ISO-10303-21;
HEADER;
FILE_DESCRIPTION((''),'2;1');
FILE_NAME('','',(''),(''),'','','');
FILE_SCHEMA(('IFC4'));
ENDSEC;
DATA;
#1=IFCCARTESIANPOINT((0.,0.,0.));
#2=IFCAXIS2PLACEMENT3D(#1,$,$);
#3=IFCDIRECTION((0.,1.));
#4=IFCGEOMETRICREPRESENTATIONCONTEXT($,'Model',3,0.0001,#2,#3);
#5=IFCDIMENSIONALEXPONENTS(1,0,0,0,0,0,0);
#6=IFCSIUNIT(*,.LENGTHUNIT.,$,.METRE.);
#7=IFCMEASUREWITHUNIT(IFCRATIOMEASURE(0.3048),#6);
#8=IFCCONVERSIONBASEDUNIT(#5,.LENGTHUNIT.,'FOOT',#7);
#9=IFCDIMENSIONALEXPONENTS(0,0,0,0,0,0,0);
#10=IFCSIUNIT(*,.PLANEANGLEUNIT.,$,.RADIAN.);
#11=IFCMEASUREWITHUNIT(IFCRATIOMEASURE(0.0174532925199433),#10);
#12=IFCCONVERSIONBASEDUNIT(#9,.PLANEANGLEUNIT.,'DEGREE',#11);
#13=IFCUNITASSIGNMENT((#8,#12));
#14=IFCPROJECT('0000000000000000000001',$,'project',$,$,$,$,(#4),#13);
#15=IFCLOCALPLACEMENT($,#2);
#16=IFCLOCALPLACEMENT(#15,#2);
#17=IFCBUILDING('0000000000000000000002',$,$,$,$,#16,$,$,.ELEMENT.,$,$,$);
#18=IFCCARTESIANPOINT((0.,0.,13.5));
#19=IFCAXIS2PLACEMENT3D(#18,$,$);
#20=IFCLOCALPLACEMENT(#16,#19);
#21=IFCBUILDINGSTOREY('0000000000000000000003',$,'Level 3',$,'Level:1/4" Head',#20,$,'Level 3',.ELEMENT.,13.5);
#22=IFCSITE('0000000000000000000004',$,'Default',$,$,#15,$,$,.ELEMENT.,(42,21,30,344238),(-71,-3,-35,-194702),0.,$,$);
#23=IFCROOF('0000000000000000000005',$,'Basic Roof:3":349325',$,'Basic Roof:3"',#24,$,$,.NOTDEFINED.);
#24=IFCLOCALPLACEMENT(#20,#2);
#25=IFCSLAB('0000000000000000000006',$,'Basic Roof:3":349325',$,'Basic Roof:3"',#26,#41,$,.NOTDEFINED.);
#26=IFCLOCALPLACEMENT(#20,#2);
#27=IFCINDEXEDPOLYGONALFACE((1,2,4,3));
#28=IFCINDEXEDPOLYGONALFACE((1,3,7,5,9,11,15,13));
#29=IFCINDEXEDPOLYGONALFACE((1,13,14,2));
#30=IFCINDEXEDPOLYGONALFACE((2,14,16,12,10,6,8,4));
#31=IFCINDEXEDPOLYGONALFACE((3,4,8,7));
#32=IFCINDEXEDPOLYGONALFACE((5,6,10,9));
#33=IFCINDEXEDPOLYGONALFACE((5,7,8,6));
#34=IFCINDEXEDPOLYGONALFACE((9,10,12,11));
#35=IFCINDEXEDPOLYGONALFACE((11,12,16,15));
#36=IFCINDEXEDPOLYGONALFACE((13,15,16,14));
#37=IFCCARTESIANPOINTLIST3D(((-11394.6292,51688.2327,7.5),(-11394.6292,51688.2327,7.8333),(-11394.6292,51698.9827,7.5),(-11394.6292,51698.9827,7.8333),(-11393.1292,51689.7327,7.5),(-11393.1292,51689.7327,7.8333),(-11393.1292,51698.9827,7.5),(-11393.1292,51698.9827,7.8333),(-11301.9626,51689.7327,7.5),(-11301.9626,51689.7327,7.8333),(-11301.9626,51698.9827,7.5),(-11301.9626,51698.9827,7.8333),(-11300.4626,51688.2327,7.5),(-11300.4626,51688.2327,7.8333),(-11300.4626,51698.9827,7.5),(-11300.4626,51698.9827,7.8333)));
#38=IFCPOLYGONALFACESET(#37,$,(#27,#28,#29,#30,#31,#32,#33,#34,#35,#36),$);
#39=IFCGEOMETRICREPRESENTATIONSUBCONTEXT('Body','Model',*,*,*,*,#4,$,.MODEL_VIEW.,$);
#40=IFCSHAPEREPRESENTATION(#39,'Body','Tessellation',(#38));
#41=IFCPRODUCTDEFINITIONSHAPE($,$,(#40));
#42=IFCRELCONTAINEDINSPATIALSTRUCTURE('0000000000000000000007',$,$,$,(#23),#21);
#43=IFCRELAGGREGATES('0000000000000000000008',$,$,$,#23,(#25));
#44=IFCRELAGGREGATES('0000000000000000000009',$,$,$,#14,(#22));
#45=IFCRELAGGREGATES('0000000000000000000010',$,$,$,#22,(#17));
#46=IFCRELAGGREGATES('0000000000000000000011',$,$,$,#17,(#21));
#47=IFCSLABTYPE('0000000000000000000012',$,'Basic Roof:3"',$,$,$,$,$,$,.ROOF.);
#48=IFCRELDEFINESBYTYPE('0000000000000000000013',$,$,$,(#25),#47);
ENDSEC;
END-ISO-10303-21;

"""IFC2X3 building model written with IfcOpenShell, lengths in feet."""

from ifc_helpers import new_model, entity, si_unit, converted_unit, direction, frame, origin, place, context, subcontext, project, spatial, polyline, outline, extrude, type_object, element, aggregate, save


model = new_model("IFC2X3")

# Units and contexts
model_context = context("Model", 3, precision=0.0001, world=origin(), true_north=direction((0.0, 1.0)))
body_context = subcontext(model_context, "Body", "Model", "MODEL_VIEW")
ifc_project = project(units=[converted_unit("LENGTHUNIT", "FOOT", entity("IfcRatioMeasure", 0.3048), si_unit("LENGTHUNIT", "METRE"), dimensions=[1, 0, 0, 0, 0, 0, 0]), converted_unit("PLANEANGLEUNIT", "DEGREE", entity("IfcRatioMeasure", 0.0174532925199433), si_unit("PLANEANGLEUNIT", "RADIAN"), dimensions=[0, 0, 0, 0, 0, 0, 0])], contexts=[model_context])

# Site, building, storey
site_placement = place(None, origin())
site = spatial("IfcSite", under=ifc_project, at=site_placement, Name="Default", CompositionType="ELEMENT", RefLatitude=(42, 21, 30, 344238), RefLongitude=(-71, -3, -35, -194702), RefElevation=0.0)
building_placement = place(site_placement, origin())
building = spatial("IfcBuilding", under=site, at=building_placement, CompositionType="ELEMENT")
storey_placement = place(building_placement, frame((0.0, 0.0, 13.5)))
storey = spatial("IfcBuildingStorey", under=building, at=storey_placement, Name="Level 3", ObjectType="Level:1/4\" Head", LongName="Level 3", CompositionType="ELEMENT", Elevation=13.5)

# Roof, slab
roof_1_placement = place(storey_placement, frame((-11394.6292, 51688.2327, 7.5)))
roof_1 = element("IfcRoof", 1, at=roof_1_placement, inside=storey, Name="Basic Roof:3\":349325", ObjectType="Basic Roof:3\"", ShapeType="NOTDEFINED")
slab_type_1 = type_object("IfcSlabType", Name="Basic Roof:3\"", PredefinedType="ROOF")
slab_1_placement = place(roof_1_placement, origin())
slab_1 = element("IfcSlab", 2, at=slab_1_placement, type_object=slab_type_1, Name="Basic Roof:3\":349325", ObjectType="Basic Roof:3\"", PredefinedType="NOTDEFINED", context=body_context, shape_type="SweptSolid", body=[
    extrude(outline(polyline([(45.5833, -3.875), (-45.5833, -3.875), (-45.5833, 5.375), (-47.0833, 5.375), (-47.0833, -5.375), (47.0833, -5.375), (47.0833, 5.375), (45.5833, 5.375), (45.5833, -3.875)])), frame((47.0833, 5.375, 0.0)), (0.0, 0.0, 1.0), 0.3333),
])
aggregate(roof_1, [slab_1])

save(model, "model.ifc")
